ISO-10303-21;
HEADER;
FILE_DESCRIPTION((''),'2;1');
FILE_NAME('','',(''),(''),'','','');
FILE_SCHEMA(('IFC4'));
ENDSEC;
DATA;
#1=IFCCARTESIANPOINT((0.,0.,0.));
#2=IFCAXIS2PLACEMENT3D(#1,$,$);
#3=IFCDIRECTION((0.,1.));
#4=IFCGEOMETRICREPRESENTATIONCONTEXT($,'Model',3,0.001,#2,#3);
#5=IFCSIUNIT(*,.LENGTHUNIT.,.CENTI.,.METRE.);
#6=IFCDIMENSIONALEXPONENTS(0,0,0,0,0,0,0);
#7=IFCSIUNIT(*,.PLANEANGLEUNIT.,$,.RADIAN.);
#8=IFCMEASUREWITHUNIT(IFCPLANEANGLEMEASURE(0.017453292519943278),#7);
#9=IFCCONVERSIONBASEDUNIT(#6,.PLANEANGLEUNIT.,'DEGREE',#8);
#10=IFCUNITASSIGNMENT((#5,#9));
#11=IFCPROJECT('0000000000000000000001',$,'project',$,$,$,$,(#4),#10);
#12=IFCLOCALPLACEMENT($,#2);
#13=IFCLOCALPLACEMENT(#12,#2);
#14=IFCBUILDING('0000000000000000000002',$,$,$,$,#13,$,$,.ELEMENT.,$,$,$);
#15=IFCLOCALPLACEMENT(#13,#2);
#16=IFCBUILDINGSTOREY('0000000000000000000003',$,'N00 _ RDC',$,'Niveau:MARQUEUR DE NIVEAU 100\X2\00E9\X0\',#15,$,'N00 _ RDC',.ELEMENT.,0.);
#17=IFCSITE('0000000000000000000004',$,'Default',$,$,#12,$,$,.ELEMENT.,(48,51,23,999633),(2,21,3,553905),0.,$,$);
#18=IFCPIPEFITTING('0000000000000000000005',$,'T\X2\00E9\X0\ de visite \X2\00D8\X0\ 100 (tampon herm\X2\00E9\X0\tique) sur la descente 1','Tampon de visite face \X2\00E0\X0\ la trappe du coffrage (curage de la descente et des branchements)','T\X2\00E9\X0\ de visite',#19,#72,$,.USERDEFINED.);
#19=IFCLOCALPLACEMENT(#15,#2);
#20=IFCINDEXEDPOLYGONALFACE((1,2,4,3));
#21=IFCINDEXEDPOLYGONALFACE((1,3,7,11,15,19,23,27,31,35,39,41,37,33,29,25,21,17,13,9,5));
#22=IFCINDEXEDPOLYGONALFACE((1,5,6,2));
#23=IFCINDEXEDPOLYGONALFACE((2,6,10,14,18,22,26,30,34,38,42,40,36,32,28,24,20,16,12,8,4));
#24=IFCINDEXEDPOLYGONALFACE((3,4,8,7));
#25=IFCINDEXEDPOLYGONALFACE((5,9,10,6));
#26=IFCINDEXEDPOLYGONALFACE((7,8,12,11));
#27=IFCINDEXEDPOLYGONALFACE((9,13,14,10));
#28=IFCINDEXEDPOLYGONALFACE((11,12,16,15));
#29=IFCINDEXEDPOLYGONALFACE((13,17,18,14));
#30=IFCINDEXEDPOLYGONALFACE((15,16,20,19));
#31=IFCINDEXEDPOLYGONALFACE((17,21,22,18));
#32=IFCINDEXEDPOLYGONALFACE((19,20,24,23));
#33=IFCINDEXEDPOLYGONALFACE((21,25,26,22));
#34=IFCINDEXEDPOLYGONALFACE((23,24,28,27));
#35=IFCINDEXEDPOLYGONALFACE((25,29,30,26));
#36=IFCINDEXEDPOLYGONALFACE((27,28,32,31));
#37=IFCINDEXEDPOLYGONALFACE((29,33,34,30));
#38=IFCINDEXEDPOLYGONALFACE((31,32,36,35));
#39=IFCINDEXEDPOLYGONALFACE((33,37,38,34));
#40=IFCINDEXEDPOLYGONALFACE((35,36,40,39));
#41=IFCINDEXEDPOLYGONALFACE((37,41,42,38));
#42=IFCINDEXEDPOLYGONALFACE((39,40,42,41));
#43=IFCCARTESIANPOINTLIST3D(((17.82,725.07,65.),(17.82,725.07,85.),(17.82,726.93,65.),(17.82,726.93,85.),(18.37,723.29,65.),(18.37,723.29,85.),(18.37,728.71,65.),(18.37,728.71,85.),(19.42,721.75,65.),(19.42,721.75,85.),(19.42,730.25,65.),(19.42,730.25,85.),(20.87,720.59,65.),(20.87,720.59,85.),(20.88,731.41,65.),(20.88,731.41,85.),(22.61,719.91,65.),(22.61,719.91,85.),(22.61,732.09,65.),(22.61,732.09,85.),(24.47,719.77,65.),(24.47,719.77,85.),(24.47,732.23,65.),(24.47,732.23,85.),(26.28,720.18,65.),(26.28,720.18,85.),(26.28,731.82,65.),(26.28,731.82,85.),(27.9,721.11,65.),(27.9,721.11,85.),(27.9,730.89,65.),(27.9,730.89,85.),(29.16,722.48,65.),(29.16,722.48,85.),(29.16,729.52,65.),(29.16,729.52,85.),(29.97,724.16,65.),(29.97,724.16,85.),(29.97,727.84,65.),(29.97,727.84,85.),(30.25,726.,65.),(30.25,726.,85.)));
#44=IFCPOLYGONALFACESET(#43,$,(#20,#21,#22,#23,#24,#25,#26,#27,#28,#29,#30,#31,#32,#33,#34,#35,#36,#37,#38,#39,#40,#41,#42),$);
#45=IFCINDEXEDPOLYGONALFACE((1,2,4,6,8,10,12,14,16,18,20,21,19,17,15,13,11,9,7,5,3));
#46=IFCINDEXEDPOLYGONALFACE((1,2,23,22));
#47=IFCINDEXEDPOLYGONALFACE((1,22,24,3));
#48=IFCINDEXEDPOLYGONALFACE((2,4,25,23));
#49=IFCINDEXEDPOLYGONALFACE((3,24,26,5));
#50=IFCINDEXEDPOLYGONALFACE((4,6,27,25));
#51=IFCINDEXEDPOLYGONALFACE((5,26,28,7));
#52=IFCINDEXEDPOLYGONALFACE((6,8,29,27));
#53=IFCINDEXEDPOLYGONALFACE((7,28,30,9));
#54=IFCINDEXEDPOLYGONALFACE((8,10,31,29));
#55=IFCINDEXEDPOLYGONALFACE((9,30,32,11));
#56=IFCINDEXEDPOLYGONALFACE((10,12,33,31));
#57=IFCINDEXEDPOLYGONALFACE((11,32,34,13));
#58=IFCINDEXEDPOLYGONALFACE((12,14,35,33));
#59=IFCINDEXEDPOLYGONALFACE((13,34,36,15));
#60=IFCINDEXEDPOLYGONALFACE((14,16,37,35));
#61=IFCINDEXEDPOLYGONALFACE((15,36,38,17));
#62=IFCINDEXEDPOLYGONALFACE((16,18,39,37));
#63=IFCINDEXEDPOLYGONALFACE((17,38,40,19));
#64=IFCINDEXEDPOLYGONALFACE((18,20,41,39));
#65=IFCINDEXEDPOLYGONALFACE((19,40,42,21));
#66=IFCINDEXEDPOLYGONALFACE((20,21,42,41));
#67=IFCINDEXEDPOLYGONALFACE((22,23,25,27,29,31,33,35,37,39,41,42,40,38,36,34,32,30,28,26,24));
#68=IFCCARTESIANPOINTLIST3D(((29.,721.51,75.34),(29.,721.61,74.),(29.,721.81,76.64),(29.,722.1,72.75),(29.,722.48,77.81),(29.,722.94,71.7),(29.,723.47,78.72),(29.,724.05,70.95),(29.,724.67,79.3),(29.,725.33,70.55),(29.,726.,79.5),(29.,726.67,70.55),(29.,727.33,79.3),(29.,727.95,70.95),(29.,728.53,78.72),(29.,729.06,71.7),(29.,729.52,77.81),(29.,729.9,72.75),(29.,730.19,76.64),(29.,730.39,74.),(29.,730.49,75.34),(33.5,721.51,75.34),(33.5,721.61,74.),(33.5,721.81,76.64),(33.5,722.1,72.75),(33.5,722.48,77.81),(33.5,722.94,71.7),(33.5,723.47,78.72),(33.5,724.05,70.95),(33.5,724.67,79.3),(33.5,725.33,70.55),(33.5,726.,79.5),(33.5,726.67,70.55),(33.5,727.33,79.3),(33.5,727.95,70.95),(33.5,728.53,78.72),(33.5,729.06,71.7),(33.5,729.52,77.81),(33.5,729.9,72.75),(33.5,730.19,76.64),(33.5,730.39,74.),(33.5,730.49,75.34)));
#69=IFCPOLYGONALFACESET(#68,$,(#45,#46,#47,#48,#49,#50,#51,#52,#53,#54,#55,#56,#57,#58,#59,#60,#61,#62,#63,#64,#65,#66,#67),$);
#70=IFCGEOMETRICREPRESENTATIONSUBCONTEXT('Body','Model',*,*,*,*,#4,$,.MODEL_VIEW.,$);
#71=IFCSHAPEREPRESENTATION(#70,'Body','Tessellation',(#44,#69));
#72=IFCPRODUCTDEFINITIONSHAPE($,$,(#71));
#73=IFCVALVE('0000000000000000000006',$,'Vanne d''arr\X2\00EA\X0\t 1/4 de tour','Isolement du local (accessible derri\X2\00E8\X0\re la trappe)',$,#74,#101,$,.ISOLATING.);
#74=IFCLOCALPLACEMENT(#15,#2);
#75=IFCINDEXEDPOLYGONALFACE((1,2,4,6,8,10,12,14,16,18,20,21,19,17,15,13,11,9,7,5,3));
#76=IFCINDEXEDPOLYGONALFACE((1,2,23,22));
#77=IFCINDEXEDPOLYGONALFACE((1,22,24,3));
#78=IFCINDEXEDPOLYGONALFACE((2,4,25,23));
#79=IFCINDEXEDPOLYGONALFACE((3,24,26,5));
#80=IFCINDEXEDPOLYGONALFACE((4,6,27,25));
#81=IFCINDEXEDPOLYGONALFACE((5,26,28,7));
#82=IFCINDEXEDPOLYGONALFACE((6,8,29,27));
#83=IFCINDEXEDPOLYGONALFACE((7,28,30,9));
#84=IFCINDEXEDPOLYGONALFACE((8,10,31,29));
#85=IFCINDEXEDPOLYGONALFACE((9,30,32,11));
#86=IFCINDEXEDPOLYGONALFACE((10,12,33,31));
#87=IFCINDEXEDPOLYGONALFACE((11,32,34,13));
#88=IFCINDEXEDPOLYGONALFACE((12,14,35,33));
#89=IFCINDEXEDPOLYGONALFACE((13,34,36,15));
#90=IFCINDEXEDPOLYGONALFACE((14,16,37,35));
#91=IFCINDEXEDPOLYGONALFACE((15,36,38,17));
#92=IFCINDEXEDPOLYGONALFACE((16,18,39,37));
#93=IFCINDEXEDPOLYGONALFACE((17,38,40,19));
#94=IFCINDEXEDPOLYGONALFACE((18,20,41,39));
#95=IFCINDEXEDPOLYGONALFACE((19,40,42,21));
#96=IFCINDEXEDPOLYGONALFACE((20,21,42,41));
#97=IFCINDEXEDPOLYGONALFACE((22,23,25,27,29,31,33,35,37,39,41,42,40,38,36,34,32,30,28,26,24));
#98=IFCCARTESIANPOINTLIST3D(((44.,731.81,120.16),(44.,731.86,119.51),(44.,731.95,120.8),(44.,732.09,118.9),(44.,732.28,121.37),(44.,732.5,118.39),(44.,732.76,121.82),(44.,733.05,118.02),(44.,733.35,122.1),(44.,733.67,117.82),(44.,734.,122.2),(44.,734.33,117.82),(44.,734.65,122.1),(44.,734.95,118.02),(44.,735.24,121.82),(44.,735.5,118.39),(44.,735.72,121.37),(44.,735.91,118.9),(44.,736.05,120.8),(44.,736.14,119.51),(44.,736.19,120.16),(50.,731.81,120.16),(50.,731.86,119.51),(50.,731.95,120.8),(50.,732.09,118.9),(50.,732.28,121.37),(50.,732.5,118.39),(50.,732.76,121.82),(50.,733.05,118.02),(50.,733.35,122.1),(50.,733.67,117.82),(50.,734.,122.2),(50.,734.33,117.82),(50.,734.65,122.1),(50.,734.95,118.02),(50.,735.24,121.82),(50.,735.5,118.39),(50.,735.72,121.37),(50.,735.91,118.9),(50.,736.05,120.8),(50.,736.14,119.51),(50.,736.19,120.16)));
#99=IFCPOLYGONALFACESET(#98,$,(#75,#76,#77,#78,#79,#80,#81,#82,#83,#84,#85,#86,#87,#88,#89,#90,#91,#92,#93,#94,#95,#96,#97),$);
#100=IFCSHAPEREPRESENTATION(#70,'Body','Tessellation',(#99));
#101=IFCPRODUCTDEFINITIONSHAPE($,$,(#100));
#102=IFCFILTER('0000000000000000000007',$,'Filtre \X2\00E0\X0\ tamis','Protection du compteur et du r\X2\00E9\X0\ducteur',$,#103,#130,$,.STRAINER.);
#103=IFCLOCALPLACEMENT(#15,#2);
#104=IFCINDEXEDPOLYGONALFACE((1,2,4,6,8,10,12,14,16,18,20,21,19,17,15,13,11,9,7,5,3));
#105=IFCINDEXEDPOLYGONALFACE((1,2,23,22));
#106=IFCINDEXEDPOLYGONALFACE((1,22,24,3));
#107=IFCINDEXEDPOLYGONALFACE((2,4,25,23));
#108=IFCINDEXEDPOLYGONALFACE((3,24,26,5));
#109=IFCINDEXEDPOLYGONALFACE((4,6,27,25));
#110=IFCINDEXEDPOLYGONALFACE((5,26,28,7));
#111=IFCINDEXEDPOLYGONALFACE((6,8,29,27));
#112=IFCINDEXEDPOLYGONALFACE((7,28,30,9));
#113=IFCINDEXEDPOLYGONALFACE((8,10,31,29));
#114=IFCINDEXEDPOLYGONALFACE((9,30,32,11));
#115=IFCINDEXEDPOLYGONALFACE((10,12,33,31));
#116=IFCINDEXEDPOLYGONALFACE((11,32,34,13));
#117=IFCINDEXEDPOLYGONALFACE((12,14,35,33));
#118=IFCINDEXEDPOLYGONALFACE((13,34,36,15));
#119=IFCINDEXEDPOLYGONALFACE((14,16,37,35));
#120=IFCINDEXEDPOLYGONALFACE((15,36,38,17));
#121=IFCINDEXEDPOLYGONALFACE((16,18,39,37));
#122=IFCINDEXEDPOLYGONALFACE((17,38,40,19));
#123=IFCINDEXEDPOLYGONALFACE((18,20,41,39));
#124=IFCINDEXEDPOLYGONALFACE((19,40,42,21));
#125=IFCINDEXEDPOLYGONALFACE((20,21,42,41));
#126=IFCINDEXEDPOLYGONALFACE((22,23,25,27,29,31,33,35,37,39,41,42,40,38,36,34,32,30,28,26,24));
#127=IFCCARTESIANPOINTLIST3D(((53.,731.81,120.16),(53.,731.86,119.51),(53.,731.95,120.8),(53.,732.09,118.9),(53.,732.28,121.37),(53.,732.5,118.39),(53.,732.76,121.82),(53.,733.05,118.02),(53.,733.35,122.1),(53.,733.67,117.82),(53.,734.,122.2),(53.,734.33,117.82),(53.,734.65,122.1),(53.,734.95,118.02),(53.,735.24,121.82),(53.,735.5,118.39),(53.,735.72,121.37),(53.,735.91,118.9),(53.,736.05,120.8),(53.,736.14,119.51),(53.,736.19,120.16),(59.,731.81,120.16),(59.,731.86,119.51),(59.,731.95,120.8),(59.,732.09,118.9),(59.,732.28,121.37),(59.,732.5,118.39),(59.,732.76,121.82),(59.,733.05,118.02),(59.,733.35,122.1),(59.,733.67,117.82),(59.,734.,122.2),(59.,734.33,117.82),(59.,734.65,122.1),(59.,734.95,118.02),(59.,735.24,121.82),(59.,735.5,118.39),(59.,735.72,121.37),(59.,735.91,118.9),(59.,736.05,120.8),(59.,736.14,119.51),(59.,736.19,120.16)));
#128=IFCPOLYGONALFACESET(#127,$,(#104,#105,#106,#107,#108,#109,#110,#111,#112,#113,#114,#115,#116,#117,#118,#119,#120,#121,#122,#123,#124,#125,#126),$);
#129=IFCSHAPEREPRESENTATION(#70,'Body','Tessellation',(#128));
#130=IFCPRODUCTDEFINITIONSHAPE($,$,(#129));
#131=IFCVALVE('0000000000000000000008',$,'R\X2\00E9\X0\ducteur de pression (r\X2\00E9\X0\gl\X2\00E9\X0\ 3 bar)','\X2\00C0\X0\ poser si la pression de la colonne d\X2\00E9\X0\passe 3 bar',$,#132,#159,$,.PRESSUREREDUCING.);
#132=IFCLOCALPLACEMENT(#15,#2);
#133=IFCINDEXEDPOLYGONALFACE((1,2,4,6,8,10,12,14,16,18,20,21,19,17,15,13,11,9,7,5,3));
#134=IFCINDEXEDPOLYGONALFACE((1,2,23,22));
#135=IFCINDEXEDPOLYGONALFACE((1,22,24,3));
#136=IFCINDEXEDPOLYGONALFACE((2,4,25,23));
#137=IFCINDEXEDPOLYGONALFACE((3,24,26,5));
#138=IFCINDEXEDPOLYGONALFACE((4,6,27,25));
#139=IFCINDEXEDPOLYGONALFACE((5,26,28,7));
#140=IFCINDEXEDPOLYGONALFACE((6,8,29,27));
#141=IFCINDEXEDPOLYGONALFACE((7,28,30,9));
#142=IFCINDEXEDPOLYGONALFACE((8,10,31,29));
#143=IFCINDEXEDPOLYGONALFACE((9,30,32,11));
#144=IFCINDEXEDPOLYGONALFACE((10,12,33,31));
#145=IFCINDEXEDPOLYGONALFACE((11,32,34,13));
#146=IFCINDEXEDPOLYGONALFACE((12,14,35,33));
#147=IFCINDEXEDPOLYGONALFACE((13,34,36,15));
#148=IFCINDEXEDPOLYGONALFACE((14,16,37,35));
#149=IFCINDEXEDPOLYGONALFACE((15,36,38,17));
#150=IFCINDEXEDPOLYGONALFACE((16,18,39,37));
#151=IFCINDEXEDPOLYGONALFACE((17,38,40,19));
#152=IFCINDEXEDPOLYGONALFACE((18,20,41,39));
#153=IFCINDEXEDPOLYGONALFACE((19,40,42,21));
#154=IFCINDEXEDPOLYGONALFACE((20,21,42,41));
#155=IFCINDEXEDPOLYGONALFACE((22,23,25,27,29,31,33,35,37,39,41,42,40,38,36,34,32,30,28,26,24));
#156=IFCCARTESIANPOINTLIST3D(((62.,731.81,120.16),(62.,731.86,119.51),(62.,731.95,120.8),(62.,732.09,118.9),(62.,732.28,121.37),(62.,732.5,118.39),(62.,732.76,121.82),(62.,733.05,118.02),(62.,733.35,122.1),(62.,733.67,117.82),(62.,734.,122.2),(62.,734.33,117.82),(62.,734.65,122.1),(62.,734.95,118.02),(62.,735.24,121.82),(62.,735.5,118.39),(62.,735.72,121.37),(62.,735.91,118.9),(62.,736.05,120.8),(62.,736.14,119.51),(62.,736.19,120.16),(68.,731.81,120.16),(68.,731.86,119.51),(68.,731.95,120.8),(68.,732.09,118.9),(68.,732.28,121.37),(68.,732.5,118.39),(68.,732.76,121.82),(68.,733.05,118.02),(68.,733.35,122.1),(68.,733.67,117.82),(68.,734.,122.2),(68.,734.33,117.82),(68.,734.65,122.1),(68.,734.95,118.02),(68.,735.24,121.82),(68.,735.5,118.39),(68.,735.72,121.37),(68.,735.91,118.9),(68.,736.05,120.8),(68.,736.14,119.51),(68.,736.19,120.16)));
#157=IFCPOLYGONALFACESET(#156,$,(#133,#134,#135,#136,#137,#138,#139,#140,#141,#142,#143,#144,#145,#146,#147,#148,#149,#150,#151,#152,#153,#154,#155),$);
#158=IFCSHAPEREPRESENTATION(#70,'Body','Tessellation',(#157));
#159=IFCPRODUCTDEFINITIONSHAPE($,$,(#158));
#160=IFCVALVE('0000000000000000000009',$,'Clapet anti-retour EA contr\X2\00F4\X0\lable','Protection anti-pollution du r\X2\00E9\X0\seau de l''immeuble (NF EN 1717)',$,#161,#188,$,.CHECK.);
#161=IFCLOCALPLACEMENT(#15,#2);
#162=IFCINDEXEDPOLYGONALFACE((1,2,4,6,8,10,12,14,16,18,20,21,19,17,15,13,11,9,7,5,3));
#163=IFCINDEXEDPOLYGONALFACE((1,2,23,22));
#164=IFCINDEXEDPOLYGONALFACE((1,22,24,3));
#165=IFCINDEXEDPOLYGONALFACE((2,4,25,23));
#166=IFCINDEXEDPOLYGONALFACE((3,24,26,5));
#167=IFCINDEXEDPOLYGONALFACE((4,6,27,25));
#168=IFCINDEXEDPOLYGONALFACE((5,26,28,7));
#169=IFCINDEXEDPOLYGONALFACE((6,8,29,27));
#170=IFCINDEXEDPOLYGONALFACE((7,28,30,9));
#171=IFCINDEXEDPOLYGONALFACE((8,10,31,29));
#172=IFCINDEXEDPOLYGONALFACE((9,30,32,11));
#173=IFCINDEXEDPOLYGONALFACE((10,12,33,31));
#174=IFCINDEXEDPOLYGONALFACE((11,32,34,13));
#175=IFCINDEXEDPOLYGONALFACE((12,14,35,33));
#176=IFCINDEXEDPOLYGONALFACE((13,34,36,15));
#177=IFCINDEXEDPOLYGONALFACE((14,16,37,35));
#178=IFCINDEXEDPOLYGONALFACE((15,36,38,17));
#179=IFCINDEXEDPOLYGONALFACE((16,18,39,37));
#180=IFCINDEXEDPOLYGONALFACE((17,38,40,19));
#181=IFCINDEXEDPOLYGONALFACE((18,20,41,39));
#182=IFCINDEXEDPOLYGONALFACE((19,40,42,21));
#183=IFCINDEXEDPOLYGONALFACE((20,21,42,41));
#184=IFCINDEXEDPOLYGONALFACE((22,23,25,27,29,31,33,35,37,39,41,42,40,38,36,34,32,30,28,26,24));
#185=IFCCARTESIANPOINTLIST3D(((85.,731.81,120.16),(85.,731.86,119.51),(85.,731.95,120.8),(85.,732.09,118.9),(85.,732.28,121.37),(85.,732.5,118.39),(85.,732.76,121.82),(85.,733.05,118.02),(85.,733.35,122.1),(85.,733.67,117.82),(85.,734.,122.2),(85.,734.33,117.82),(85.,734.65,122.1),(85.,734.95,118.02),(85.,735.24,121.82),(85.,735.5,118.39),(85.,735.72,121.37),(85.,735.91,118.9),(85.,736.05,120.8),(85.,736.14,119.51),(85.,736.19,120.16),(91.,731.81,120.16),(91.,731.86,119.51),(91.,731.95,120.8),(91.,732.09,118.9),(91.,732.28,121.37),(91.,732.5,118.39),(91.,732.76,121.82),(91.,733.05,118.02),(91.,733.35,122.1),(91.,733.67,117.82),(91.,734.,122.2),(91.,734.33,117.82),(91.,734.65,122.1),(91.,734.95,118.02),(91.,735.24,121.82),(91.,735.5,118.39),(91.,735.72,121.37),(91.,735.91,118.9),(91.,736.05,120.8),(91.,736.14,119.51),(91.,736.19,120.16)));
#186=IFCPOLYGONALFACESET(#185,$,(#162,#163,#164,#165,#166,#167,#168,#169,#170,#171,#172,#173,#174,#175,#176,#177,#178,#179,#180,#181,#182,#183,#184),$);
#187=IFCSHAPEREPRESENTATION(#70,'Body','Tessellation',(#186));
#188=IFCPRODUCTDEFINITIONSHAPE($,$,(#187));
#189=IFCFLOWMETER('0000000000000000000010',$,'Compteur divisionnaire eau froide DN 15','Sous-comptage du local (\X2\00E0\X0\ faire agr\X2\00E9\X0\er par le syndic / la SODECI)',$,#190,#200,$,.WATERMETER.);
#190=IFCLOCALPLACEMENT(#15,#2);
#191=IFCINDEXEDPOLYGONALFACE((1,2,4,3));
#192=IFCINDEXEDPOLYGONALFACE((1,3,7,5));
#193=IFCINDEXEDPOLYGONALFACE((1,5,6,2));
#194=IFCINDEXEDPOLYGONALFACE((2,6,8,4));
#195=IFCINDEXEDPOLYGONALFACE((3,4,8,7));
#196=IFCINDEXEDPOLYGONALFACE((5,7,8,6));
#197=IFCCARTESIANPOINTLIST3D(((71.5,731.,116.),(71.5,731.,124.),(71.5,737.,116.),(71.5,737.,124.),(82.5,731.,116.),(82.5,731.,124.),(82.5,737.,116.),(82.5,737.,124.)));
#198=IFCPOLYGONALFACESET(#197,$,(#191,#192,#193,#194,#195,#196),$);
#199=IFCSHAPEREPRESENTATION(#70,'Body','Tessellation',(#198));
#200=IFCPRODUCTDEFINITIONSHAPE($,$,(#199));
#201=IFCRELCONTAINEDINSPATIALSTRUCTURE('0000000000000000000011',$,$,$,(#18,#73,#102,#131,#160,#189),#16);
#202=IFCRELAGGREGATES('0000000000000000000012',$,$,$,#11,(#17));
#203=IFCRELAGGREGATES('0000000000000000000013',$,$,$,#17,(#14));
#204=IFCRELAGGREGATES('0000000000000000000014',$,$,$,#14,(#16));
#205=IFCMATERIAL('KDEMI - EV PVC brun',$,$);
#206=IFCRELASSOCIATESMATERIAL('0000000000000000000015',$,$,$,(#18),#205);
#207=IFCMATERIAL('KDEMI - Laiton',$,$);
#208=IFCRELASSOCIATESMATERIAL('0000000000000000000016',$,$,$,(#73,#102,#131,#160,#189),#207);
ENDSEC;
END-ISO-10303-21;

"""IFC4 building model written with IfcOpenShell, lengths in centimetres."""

from ifc_helpers import new_model, entity, si_unit, converted_unit, direction, frame, frame_2d, origin, origin_with_axes, place, context, subcontext, project, spatial, rectangle, circle, extrude, material, element, save


model = new_model("IFC4")

# Units and contexts
model_context = context("Model", 3, precision=0.001, world=origin(), true_north=direction((0.0, 1.0)))
body_context = subcontext(model_context, "Body", "Model", "MODEL_VIEW")
ifc_project = project(units=[si_unit("LENGTHUNIT", "METRE", prefix="CENTI"), converted_unit("PLANEANGLEUNIT", "DEGREE", entity("IfcPlaneAngleMeasure", 0.017453292519943278), si_unit("PLANEANGLEUNIT", "RADIAN"), dimensions=[0, 0, 0, 0, 0, 0, 0])], contexts=[model_context])

# Site, building, storey
site_placement = place(None, origin())
site = spatial("IfcSite", under=ifc_project, at=site_placement, Name="Default", CompositionType="ELEMENT", RefLatitude=(48, 51, 23, 999633), RefLongitude=(2, 21, 3, 553905), RefElevation=0.0)
building_placement = place(site_placement, origin())
building = spatial("IfcBuilding", under=site, at=building_placement, CompositionType="ELEMENT")
storey_placement = place(building_placement, origin())
storey = spatial("IfcBuildingStorey", under=building, at=storey_placement, Name="N00 _ RDC", ObjectType="Niveau:MARQUEUR DE NIVEAU 100é", LongName="N00 _ RDC", CompositionType="ELEMENT", Elevation=0.0)

# Shared definitions
ifc_material_1 = material(Name="KDEMI - EV PVC brun")

# Pipe fitting
pipe_fitting_1_placement = place(storey_placement, origin_with_axes())
element("IfcPipeFitting", 1, at=pipe_fitting_1_placement, inside=storey, material=ifc_material_1, Name="Té de visite Ø 100 (tampon hermétique) sur la descente 1", Description="Tampon de visite face à la trappe du coffrage (curage de la descente et des branchements)", ObjectType="Té de visite", PredefinedType="USERDEFINED", context=body_context, shape_type="AdvancedSweptSolid", body=[
    extrude(circle(Radius=6.25, at=frame_2d((24.0, 726.0))), frame((0.0, 0.0, 65.0)), (0.0, 0.0, 1.0), 20.0),
    entity("IfcSweptDiskSolid", entity("IfcPolyline", [entity("IfcCartesianPoint", [29.0, 726.0, 75.0]), entity("IfcCartesianPoint", [33.5, 726.0, 75.0])]), 4.5),
])

# Valve
ifc_material_2 = material(Name="KDEMI - Laiton")
valve_1_placement = place(storey_placement, origin_with_axes())
element("IfcValve", 2, at=valve_1_placement, inside=storey, material=ifc_material_2, Name="Vanne d'arrêt 1/4 de tour", Description="Isolement du local (accessible derrière la trappe)", PredefinedType="ISOLATING", context=body_context, shape_type="AdvancedSweptSolid", body=[
    entity("IfcSweptDiskSolid", entity("IfcPolyline", [entity("IfcCartesianPoint", [44.0, 734.0, 120.0]), entity("IfcCartesianPoint", [50.0, 734.0, 120.0])]), 2.2),
])

# Filter
ifc_filter_placement = place(storey_placement, origin_with_axes())
element("IfcFilter", 3, at=ifc_filter_placement, inside=storey, material=ifc_material_2, Name="Filtre à tamis", Description="Protection du compteur et du réducteur", PredefinedType="STRAINER", context=body_context, shape_type="AdvancedSweptSolid", body=[
    entity("IfcSweptDiskSolid", entity("IfcPolyline", [entity("IfcCartesianPoint", [53.0, 734.0, 120.0]), entity("IfcCartesianPoint", [59.0, 734.0, 120.0])]), 2.2),
])

# Valves
valve_2_placement = place(storey_placement, origin_with_axes())
element("IfcValve", 4, at=valve_2_placement, inside=storey, material=ifc_material_2, Name="Réducteur de pression (réglé 3 bar)", Description="À poser si la pression de la colonne dépasse 3 bar", PredefinedType="PRESSUREREDUCING", context=body_context, shape_type="AdvancedSweptSolid", body=[
    entity("IfcSweptDiskSolid", entity("IfcPolyline", [entity("IfcCartesianPoint", [62.0, 734.0, 120.0]), entity("IfcCartesianPoint", [68.0, 734.0, 120.0])]), 2.2),
])
valve_3_placement = place(storey_placement, origin_with_axes())
element("IfcValve", 5, at=valve_3_placement, inside=storey, material=ifc_material_2, Name="Clapet anti-retour EA contrôlable", Description="Protection anti-pollution du réseau de l'immeuble (NF EN 1717)", PredefinedType="CHECK", context=body_context, shape_type="AdvancedSweptSolid", body=[
    entity("IfcSweptDiskSolid", entity("IfcPolyline", [entity("IfcCartesianPoint", [85.0, 734.0, 120.0]), entity("IfcCartesianPoint", [91.0, 734.0, 120.0])]), 2.2),
])

# Flow meter
flow_meter_placement = place(storey_placement, origin_with_axes())
element("IfcFlowMeter", 6, at=flow_meter_placement, inside=storey, material=ifc_material_2, Name="Compteur divisionnaire eau froide DN 15", Description="Sous-comptage du local (à faire agréer par le syndic / la SODECI)", PredefinedType="WATERMETER", context=body_context, shape_type="SweptSolid", body=[
    extrude(rectangle(XDim=11.0, YDim=6.0, at=frame_2d((77.0, 734.0))), frame((0.0, 0.0, 116.0)), (0.0, 0.0, 1.0), 8.0),
])

save(model, "model.ifc")
